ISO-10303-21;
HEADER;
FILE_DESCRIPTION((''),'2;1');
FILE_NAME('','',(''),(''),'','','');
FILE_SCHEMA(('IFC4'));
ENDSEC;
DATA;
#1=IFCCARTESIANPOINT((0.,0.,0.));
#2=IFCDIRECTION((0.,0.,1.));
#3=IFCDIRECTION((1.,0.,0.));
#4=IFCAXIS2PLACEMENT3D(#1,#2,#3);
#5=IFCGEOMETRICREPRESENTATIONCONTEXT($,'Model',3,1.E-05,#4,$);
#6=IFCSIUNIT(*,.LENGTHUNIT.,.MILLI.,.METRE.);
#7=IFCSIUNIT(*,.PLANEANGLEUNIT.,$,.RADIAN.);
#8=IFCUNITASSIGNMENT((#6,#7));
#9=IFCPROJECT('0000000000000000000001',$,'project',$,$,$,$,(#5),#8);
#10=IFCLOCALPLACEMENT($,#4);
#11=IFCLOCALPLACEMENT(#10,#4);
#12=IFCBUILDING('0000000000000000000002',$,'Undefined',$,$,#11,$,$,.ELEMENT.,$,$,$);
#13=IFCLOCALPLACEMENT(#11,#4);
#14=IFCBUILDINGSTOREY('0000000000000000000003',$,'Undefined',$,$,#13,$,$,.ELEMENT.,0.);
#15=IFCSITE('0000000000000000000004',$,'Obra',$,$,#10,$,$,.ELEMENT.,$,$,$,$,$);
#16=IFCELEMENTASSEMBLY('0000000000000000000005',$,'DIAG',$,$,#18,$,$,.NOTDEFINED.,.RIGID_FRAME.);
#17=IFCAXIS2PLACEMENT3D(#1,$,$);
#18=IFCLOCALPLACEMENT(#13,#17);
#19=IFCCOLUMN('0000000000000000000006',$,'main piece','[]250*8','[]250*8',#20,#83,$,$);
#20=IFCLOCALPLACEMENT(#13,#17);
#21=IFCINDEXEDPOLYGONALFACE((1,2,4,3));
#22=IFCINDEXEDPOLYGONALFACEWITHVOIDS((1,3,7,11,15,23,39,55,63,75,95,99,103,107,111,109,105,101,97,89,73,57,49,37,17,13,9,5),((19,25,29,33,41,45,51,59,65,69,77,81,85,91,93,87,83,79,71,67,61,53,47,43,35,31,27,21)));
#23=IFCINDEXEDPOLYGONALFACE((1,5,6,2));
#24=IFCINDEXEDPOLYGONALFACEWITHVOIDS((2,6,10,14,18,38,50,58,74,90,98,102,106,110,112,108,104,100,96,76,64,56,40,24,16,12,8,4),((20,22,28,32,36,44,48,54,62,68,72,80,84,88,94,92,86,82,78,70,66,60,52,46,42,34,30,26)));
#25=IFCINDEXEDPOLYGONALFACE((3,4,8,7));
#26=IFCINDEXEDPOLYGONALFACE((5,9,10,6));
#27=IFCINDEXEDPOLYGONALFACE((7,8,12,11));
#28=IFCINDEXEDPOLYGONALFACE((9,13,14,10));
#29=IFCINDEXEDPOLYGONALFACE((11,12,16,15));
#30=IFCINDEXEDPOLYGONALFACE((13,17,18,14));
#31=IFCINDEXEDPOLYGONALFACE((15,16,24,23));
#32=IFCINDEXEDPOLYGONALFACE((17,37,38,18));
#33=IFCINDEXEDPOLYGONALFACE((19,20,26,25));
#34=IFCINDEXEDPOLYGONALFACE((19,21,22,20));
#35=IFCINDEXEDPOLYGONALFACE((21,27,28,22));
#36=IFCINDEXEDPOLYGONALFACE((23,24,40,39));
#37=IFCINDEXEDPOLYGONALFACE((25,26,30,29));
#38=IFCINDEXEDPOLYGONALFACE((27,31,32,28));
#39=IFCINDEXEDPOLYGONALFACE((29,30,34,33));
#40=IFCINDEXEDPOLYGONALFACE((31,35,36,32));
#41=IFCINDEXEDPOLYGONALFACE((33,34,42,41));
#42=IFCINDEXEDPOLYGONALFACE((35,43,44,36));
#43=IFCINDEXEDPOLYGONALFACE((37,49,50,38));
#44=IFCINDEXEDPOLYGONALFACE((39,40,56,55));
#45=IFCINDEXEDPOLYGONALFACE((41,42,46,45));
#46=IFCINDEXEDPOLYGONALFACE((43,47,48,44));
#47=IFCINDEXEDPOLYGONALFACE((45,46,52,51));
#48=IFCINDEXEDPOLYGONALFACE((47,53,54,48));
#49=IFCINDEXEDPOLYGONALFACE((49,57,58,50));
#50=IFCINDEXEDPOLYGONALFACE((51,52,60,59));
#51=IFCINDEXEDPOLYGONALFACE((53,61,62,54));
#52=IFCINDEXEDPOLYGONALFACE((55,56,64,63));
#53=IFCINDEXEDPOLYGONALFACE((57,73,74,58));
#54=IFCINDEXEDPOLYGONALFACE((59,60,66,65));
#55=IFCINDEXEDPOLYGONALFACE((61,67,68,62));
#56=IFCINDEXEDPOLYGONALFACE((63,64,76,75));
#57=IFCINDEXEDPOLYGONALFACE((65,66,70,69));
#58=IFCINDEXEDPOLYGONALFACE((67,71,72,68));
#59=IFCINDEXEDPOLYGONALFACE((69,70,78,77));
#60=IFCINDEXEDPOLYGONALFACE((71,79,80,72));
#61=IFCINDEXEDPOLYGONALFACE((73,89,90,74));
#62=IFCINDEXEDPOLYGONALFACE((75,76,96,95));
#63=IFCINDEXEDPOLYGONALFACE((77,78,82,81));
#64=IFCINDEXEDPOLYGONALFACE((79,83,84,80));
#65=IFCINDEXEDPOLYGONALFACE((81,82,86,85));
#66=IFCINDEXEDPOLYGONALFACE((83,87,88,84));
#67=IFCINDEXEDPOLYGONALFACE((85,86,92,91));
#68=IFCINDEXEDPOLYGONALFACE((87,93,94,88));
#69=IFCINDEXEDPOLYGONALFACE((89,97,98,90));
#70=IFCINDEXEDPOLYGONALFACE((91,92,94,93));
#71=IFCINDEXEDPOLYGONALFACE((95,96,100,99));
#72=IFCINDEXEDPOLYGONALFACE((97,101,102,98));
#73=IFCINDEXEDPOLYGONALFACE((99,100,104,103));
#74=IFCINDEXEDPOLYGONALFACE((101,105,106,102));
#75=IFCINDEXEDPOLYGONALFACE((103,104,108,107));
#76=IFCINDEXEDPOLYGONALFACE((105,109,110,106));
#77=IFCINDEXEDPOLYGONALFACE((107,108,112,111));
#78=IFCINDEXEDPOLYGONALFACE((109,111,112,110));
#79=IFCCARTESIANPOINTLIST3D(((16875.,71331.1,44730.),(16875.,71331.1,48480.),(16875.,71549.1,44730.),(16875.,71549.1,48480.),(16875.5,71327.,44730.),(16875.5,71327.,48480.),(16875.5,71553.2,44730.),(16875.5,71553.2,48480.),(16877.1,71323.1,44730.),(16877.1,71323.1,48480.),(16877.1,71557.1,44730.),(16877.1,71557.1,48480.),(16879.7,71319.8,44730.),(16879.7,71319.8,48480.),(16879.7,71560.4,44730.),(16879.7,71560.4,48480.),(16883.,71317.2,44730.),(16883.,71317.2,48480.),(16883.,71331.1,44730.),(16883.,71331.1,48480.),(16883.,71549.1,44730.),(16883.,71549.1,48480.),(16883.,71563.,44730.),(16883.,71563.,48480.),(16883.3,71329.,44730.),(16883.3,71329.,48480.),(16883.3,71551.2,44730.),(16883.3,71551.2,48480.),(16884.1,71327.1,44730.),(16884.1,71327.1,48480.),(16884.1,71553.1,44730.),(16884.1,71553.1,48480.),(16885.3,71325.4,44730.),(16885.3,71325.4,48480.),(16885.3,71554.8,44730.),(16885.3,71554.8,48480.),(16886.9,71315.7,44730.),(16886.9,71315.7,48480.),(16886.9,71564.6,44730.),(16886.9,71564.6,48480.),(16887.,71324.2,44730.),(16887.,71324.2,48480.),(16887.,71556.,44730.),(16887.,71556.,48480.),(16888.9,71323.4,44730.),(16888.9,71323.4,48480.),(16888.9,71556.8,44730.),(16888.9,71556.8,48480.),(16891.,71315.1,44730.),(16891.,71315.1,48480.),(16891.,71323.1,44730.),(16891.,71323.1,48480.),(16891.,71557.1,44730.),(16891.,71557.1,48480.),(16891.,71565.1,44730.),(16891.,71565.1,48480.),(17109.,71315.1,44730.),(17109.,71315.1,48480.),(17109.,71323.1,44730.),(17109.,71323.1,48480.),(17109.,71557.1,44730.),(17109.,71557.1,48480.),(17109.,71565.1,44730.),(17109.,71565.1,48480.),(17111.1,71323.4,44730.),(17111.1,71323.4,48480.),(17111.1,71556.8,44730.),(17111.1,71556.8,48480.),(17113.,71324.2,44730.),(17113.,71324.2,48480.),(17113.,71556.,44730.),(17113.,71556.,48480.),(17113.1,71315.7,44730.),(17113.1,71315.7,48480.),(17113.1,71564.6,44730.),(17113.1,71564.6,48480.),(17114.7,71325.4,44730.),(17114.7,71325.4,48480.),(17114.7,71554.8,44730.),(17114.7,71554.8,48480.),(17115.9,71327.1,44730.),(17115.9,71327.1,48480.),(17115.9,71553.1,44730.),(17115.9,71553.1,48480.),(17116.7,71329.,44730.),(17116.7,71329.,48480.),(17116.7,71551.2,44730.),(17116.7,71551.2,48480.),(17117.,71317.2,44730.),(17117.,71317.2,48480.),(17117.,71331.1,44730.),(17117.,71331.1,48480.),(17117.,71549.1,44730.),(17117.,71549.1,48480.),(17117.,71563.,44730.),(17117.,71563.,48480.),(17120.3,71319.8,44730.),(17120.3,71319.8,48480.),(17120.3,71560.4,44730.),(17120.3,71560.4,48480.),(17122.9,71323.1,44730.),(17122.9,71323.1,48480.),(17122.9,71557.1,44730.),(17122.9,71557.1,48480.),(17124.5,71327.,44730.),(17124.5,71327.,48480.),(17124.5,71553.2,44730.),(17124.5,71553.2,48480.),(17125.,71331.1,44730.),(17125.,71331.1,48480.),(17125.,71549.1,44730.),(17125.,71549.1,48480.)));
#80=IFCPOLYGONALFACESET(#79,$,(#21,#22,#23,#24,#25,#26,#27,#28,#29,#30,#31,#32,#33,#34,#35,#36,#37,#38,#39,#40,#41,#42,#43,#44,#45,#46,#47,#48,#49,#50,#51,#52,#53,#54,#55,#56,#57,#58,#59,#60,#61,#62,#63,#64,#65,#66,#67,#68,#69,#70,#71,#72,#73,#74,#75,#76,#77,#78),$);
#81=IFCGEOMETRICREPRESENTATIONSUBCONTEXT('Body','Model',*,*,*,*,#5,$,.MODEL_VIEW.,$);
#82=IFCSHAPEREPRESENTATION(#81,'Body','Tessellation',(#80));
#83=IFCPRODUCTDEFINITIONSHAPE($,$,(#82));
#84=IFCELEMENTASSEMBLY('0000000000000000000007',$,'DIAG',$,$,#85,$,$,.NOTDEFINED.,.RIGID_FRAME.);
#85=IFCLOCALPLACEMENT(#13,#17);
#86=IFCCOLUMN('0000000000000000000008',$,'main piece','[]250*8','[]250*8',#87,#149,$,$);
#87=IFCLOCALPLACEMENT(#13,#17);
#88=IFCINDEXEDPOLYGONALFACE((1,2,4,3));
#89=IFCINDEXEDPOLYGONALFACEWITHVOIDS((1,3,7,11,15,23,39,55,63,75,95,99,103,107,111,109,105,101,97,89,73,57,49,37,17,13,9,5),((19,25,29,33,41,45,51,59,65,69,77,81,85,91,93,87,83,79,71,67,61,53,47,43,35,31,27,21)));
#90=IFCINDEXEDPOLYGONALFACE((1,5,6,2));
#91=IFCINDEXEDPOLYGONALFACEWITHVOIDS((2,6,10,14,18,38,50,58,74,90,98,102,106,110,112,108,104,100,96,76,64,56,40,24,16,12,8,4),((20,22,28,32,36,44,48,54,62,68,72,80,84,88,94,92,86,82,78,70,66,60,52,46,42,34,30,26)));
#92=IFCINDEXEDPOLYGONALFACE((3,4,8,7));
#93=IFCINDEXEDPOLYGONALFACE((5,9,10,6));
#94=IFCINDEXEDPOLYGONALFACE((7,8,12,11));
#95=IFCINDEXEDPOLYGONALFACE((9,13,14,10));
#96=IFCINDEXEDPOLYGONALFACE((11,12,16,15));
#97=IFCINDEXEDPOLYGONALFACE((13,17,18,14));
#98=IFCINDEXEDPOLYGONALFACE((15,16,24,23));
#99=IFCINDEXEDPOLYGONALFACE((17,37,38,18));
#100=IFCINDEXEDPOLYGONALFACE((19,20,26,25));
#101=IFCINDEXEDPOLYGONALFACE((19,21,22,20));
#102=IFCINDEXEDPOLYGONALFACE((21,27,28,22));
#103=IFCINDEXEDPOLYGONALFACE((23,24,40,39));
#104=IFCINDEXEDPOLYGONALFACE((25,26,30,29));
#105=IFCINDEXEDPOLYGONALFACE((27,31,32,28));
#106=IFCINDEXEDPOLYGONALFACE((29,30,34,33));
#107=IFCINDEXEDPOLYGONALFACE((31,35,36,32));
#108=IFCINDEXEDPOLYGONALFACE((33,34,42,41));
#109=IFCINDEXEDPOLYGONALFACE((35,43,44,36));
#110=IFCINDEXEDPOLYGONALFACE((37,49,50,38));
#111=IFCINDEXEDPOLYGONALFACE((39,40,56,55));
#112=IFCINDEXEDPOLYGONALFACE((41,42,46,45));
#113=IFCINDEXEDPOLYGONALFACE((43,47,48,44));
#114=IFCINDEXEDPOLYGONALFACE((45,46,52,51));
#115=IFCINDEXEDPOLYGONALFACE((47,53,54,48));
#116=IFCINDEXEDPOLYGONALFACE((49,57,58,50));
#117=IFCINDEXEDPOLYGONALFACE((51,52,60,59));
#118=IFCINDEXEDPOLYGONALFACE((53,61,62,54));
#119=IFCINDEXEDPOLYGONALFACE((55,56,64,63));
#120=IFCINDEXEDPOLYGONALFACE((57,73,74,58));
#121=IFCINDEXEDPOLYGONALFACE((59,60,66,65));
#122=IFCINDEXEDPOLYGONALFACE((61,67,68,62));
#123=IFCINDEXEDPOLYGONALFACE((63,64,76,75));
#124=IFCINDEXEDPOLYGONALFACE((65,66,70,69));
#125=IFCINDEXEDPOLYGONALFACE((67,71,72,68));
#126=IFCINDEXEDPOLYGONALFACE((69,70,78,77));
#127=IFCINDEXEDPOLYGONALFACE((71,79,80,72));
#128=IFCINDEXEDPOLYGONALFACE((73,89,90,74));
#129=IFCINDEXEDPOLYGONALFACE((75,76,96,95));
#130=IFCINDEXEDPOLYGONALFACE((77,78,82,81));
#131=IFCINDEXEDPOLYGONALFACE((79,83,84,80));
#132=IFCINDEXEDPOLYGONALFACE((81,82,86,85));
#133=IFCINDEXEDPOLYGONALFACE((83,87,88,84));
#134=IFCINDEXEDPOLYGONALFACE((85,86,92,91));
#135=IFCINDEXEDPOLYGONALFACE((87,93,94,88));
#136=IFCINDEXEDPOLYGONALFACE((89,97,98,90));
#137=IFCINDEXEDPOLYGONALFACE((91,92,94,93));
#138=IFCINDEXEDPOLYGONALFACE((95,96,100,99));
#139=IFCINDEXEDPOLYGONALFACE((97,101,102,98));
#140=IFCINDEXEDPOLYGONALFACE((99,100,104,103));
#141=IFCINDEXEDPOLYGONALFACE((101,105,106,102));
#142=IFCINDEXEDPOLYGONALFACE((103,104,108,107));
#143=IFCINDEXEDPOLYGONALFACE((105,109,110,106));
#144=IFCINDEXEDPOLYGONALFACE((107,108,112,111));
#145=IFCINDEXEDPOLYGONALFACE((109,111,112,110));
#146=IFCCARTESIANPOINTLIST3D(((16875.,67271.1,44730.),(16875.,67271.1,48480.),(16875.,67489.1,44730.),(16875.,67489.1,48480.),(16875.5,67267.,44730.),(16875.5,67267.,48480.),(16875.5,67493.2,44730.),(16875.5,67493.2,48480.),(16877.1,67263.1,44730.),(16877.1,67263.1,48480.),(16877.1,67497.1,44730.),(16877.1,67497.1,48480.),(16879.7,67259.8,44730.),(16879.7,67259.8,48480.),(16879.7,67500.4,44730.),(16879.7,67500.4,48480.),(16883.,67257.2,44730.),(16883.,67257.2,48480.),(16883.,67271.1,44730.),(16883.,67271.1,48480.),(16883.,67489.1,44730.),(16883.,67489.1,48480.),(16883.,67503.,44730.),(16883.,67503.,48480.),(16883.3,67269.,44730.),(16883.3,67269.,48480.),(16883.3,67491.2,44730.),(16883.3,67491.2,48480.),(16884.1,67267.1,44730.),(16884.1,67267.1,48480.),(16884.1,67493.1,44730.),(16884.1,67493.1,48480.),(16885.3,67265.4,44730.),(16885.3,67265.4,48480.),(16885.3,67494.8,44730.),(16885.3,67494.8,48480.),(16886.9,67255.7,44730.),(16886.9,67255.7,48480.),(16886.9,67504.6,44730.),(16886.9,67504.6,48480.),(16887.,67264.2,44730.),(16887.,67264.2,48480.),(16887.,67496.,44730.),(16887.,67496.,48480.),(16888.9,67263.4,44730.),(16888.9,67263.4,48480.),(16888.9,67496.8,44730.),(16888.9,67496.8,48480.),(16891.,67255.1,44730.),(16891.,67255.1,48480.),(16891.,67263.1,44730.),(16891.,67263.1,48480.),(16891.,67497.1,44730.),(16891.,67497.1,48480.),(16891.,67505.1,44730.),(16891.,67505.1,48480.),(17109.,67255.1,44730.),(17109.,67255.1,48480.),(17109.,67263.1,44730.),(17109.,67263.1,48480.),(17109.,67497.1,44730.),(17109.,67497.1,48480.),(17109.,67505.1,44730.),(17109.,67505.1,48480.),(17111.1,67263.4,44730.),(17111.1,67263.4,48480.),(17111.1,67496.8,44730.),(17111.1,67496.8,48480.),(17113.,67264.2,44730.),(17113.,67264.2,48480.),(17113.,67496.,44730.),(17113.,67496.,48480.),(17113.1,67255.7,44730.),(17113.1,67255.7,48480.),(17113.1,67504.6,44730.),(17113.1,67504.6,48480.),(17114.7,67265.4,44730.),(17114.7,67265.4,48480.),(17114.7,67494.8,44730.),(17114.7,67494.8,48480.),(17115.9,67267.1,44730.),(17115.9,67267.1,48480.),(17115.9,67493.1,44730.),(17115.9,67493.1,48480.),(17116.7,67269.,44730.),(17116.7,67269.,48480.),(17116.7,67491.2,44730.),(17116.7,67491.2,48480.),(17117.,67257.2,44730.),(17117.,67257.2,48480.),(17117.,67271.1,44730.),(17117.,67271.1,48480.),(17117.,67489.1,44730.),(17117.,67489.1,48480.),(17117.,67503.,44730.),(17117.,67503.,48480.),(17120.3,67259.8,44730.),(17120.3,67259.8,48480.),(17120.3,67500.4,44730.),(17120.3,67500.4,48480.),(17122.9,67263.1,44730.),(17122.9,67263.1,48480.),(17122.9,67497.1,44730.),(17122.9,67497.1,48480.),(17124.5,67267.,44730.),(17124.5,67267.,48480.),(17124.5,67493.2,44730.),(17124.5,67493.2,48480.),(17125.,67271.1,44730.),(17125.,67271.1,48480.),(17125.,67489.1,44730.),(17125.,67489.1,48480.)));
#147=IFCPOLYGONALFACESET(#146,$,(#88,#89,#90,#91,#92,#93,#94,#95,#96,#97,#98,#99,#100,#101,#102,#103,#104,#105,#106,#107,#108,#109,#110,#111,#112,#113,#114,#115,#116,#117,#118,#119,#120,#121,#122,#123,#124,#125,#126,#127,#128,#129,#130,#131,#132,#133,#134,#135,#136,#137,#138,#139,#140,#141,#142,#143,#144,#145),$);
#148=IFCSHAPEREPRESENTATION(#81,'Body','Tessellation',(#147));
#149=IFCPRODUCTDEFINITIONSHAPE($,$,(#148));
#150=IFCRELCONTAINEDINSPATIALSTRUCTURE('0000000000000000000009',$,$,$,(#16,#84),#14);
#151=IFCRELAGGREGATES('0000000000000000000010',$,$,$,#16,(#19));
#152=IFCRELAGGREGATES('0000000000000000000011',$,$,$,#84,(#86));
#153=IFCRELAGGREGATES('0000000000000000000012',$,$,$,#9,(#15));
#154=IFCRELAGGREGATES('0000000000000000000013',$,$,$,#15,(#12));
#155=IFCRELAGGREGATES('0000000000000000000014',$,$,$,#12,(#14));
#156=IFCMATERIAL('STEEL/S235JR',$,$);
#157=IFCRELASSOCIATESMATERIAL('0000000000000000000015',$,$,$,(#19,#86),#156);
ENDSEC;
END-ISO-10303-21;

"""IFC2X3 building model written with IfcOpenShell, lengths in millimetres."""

from ifc_helpers import new_model, si_unit, frame, origin_with_axes, origin_2d_with_axis, place, context, subcontext, project, spatial, hollow_rectangle, extrude, material, element, aggregate, save


model = new_model("IFC2X3")

# Units and contexts
model_context = context("Model", 3, precision=1e-05, world=origin_with_axes())
body_context = subcontext(model_context, "Body", "Model", "MODEL_VIEW")
ifc_project = project(units=[si_unit("LENGTHUNIT", "METRE", prefix="MILLI"), si_unit("PLANEANGLEUNIT", "RADIAN")], contexts=[model_context])

# Site, building, storey
site_placement = place(None, origin_with_axes())
site = spatial("IfcSite", under=ifc_project, at=site_placement, Name="Obra", CompositionType="ELEMENT")
building_placement = place(site_placement, origin_with_axes())
building = spatial("IfcBuilding", under=site, at=building_placement, Name="Undefined", CompositionType="ELEMENT")
storey_placement = place(building_placement, origin_with_axes())
storey = spatial("IfcBuildingStorey", under=building, at=storey_placement, Name="Undefined", CompositionType="ELEMENT", Elevation=0.0)

# Element assemblies, columns
ifc_material = material(Name="STEEL/S235JR")
assembly_1_placement = place(storey_placement, origin_with_axes())
assembly_1 = element("IfcElementAssembly", 1, at=assembly_1_placement, inside=storey, Name="DIAG", AssemblyPlace="NOTDEFINED", PredefinedType="RIGID_FRAME")
column_1_placement = place(assembly_1_placement, frame((17000.0, 71440.1, 44730.0), z_axis=(0.0, 0.0, 1.0), x_axis=(-1.0, 0.0, 0.0)))
column_1 = element("IfcColumn", 2, at=column_1_placement, material=ifc_material, Name="main piece", Description="[]250*8", ObjectType="[]250*8", context=body_context, shape_type="SweptSolid", body=[
    extrude(hollow_rectangle(XDim=250.0, YDim=250.0, WallThickness=8.0, InnerFilletRadius=8.0, OuterFilletRadius=16.0, at=origin_2d_with_axis()), frame((0.0, 0.0, 3750.0), z_axis=(0.0, 0.0, -1.0), x_axis=(0.0, 1.0, 0.0)), (0.0, 0.0, 1.0), 3750.0),
])
aggregate(assembly_1, [column_1])
assembly_2_placement = place(storey_placement, origin_with_axes())
assembly_2 = element("IfcElementAssembly", 3, at=assembly_2_placement, inside=storey, Name="DIAG", AssemblyPlace="NOTDEFINED", PredefinedType="RIGID_FRAME")
column_2_placement = place(assembly_2_placement, frame((17000.0, 67380.1, 44730.0), z_axis=(0.0, 0.0, 1.0), x_axis=(-1.0, 0.0, 0.0)))
column_2 = element("IfcColumn", 4, at=column_2_placement, material=ifc_material, Name="main piece", Description="[]250*8", ObjectType="[]250*8", context=body_context, shape_type="SweptSolid", body=[
    extrude(hollow_rectangle(XDim=250.0, YDim=250.0, WallThickness=8.0, InnerFilletRadius=8.0, OuterFilletRadius=16.0, at=origin_2d_with_axis()), frame((0.0, 0.0, 3750.0), z_axis=(0.0, 0.0, -1.0), x_axis=(0.0, 1.0, 0.0)), (0.0, 0.0, 1.0), 3750.0),
])
aggregate(assembly_2, [column_2])

save(model, "model.ifc")
